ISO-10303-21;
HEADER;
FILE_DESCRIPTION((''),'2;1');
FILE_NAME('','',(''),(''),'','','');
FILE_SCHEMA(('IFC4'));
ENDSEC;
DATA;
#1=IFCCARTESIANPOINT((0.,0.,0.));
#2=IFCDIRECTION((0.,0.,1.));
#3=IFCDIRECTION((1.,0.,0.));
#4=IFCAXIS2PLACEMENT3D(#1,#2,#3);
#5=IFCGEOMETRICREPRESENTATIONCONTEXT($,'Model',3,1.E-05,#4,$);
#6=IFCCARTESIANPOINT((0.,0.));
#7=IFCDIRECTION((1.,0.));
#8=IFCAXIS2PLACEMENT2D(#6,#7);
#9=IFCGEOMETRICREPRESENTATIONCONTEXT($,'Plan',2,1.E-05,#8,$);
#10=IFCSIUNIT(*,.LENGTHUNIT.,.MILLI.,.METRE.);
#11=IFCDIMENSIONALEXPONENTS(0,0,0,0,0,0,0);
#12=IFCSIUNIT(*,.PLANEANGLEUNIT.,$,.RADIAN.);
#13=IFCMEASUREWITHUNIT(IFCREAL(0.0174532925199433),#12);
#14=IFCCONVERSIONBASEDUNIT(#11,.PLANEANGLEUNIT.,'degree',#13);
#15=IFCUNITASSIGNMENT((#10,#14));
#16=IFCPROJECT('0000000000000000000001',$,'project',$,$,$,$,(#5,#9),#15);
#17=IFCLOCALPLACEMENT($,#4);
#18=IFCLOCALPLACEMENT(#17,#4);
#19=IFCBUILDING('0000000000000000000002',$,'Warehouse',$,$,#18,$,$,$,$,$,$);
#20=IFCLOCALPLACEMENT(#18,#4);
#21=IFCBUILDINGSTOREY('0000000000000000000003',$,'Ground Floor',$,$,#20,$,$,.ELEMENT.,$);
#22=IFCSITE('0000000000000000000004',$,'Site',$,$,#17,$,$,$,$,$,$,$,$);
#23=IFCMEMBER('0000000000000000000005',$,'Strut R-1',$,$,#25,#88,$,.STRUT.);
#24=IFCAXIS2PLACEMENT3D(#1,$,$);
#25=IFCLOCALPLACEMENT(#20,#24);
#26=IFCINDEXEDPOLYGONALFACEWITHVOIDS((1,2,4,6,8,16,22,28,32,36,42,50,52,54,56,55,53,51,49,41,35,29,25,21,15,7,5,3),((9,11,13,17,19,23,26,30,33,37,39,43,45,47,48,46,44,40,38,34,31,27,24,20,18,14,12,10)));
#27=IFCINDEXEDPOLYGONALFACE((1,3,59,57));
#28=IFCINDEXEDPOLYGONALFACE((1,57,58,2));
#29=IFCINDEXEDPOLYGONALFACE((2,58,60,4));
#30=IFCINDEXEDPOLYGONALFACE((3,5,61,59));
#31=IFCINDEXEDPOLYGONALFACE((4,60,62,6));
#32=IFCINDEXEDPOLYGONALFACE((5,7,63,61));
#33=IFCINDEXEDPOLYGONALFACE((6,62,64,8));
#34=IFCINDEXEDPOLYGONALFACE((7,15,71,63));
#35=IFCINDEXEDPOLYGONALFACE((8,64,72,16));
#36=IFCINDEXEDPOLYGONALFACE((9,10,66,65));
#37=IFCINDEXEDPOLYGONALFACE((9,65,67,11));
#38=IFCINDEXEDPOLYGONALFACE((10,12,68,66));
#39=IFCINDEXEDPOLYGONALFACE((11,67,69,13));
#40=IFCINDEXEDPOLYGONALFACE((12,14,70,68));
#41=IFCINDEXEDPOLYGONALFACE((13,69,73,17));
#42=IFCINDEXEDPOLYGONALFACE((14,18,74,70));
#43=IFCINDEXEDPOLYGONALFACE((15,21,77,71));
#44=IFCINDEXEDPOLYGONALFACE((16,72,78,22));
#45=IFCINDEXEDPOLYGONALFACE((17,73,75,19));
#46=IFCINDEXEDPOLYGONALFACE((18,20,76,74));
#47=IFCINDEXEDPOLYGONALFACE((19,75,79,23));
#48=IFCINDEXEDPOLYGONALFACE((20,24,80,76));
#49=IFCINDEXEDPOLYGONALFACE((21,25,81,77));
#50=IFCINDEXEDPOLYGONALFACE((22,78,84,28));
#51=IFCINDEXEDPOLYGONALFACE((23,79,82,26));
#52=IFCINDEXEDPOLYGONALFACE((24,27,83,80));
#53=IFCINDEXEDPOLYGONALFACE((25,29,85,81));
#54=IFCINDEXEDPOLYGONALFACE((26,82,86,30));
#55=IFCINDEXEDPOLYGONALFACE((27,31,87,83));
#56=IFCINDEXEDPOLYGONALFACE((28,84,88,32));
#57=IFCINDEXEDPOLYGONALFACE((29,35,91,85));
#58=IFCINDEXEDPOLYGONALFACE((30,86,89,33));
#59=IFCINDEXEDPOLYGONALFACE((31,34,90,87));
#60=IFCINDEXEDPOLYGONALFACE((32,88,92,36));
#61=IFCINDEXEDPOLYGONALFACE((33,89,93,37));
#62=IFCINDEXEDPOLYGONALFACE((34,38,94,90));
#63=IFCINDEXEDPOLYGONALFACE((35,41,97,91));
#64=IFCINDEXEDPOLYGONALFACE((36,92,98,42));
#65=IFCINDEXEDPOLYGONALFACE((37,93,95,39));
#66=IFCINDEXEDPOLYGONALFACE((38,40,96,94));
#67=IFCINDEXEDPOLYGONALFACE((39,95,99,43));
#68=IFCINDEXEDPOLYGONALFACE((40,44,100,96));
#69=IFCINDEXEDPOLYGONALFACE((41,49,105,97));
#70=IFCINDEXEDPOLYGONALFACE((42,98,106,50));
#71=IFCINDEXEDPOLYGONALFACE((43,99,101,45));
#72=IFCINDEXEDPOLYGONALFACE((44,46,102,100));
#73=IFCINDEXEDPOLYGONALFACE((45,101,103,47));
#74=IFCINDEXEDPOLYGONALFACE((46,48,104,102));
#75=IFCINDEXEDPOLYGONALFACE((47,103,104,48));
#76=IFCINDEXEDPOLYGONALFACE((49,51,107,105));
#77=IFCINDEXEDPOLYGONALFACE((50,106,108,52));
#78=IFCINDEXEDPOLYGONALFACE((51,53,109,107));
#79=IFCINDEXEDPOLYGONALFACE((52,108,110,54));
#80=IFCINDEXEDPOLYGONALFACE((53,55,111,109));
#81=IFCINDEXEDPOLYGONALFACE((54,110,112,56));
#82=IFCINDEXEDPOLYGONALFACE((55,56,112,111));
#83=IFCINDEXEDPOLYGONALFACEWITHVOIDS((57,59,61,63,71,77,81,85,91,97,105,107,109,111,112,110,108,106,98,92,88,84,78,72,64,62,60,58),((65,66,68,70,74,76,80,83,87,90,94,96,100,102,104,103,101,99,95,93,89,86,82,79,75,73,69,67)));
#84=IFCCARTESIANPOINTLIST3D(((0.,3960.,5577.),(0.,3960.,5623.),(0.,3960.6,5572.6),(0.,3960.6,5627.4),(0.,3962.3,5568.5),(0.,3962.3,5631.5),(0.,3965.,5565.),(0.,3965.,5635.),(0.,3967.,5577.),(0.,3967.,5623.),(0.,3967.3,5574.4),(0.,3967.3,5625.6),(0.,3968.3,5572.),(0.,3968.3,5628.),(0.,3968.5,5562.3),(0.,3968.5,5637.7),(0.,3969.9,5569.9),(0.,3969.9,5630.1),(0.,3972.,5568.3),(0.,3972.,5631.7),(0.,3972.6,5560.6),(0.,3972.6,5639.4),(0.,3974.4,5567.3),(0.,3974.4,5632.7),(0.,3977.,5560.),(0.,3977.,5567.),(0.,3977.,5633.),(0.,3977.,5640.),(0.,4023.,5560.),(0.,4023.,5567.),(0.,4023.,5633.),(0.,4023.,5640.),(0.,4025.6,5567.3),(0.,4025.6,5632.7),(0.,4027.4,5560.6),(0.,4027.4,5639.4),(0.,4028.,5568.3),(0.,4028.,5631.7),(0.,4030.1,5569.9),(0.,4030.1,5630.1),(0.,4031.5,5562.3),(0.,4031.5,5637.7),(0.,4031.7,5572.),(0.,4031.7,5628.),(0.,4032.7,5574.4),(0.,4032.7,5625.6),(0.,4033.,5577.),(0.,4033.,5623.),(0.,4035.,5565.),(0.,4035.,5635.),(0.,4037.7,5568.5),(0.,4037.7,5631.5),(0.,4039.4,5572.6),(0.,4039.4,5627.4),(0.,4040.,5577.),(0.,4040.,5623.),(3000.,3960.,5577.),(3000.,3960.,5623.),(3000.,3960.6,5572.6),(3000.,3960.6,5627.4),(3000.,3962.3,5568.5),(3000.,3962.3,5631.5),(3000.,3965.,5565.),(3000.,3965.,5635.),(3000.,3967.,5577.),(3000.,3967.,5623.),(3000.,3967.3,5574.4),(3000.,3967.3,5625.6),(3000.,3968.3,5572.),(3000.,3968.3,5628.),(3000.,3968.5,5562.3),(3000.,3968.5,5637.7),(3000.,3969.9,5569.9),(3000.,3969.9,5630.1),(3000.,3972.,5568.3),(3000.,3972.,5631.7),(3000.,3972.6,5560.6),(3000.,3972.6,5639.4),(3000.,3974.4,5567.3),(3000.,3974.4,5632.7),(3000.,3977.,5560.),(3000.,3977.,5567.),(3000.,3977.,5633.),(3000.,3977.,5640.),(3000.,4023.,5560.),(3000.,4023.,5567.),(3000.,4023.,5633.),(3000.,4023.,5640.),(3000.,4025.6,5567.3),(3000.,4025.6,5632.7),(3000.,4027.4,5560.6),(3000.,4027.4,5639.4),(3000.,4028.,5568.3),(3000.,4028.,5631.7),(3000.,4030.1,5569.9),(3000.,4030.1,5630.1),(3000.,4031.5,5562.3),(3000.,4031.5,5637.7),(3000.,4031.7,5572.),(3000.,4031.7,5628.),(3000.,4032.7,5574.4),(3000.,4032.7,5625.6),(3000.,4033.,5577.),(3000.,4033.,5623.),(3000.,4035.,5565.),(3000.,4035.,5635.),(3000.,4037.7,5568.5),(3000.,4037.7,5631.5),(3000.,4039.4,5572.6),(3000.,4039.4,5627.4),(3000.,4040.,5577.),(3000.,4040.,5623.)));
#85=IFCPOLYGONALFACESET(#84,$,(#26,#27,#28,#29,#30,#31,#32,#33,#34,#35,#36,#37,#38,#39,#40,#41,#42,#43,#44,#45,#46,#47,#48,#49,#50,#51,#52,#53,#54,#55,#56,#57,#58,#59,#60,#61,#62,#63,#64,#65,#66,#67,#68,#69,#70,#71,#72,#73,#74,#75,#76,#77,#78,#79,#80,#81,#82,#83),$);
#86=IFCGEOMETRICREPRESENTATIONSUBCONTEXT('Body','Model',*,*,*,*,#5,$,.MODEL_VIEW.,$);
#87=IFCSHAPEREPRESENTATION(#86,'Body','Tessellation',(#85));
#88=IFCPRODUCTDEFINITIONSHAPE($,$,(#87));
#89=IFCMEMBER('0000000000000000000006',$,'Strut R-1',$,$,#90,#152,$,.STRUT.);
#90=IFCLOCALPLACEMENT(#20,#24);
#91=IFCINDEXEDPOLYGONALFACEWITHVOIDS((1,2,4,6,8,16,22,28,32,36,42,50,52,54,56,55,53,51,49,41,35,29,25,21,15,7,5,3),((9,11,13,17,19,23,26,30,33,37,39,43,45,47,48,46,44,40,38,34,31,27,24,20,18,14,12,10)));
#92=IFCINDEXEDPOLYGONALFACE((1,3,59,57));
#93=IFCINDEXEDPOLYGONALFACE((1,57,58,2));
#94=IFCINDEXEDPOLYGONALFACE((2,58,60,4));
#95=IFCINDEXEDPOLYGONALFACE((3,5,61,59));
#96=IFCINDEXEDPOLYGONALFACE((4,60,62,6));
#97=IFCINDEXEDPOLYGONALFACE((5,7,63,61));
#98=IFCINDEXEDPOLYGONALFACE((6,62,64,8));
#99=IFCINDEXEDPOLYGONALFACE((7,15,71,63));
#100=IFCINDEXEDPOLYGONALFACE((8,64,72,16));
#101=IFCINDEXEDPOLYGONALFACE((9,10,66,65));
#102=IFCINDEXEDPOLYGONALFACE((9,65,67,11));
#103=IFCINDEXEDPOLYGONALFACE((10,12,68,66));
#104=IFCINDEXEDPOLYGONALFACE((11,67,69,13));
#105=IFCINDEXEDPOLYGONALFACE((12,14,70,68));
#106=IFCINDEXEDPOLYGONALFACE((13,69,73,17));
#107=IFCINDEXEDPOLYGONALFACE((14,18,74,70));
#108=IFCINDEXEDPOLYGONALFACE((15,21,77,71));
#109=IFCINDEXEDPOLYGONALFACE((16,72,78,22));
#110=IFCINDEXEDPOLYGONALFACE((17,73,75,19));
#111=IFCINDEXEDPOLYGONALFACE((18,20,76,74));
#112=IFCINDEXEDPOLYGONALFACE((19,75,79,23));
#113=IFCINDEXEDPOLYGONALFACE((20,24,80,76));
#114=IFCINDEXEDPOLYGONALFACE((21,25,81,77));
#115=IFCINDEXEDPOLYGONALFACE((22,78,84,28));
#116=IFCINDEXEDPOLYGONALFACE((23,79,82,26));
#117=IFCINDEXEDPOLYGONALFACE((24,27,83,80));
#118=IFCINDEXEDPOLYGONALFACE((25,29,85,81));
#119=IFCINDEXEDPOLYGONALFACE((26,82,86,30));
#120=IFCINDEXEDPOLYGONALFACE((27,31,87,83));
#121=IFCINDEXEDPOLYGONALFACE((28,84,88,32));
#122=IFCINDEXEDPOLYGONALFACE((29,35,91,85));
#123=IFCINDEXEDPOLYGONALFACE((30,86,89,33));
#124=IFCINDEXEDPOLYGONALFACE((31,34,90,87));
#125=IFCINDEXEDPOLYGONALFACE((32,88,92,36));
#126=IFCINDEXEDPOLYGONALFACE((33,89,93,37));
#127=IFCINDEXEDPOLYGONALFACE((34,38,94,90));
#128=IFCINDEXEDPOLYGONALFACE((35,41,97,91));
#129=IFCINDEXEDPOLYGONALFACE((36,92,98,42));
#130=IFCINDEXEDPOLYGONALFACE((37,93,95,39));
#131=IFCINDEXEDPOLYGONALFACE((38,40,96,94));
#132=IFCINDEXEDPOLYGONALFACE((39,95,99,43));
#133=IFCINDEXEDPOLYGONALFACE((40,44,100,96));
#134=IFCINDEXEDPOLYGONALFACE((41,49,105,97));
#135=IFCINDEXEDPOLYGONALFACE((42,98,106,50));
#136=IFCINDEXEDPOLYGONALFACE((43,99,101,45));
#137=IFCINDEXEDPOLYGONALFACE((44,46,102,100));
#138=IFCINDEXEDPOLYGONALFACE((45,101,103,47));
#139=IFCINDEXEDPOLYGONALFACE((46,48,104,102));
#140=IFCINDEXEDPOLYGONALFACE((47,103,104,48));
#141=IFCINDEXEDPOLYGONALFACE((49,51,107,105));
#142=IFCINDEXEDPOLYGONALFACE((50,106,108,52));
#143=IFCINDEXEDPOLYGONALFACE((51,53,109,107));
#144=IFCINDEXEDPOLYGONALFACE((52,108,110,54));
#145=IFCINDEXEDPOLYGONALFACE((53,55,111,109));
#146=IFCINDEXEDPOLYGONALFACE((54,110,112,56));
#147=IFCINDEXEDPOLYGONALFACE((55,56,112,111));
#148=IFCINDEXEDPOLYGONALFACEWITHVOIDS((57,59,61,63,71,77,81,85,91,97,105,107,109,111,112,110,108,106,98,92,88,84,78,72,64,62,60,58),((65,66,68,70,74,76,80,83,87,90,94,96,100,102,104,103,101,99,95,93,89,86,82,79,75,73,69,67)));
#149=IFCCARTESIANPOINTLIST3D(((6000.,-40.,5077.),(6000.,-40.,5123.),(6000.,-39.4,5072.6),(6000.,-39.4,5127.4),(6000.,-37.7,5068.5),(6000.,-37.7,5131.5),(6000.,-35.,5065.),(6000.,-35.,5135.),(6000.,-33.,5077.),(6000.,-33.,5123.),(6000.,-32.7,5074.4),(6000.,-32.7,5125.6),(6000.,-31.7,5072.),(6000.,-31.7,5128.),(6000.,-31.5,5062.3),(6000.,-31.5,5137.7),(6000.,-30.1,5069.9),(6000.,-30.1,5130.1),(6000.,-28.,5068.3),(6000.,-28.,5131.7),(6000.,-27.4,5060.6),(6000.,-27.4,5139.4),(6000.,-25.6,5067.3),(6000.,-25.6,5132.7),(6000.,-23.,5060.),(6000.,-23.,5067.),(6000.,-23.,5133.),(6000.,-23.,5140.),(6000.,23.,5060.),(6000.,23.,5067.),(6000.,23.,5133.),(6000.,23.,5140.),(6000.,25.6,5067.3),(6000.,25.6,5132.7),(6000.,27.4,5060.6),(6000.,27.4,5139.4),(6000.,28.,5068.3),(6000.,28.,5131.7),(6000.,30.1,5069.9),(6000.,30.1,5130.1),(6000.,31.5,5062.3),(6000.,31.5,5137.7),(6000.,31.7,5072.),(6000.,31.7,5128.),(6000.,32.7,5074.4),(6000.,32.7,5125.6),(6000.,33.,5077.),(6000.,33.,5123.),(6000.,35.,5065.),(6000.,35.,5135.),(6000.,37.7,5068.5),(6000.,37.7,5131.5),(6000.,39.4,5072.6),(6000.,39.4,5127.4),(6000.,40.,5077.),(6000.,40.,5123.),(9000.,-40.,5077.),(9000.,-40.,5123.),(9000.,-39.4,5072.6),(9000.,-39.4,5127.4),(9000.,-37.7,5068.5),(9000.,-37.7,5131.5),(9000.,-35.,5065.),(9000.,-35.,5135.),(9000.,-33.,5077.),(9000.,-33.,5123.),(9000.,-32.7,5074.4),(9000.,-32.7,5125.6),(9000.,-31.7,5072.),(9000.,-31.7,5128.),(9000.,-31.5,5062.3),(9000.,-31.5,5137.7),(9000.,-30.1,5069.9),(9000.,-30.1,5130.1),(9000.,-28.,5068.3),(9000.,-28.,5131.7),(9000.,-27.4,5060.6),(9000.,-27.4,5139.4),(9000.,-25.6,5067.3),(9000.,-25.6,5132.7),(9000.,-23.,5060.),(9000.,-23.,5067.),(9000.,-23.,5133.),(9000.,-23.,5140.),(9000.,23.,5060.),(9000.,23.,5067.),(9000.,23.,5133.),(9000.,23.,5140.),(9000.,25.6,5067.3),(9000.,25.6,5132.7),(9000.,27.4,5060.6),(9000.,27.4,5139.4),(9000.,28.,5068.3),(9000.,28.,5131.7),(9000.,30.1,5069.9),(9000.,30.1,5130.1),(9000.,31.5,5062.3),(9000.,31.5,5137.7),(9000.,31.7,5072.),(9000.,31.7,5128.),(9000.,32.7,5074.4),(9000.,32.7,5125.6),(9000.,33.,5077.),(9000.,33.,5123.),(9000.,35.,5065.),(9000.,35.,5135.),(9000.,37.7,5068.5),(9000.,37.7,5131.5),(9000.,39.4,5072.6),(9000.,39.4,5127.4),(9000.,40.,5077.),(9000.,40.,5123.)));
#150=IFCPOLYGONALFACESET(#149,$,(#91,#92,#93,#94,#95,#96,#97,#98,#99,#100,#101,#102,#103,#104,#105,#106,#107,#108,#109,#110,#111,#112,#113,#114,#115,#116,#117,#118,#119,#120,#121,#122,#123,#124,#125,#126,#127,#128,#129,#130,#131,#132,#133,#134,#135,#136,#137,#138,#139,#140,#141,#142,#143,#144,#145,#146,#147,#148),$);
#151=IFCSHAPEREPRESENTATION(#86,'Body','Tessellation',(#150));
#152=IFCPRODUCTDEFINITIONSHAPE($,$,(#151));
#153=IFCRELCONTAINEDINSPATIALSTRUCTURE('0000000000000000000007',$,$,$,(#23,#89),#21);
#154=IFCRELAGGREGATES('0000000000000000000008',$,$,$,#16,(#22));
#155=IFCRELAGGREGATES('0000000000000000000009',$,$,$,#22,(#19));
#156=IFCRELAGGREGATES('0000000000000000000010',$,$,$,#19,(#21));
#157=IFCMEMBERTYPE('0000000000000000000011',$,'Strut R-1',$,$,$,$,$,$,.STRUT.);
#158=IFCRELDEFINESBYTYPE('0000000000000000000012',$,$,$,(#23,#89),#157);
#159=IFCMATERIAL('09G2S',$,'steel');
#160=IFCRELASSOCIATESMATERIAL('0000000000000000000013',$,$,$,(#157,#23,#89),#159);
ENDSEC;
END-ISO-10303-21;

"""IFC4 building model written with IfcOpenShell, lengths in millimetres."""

from ifc_helpers import new_model, entity, si_unit, converted_unit, frame, origin_with_axes, origin_2d_with_axis, place, context, subcontext, project, spatial, hollow_rectangle, extrude, material, material_profile, profile_set, profile_usage, type_object, element, save


model = new_model("IFC4")

# Units and contexts
model_context = context("Model", 3, precision=1e-05, world=origin_with_axes())
plan_context = context("Plan", 2, precision=1e-05, world=origin_2d_with_axis())
body_context = subcontext(model_context, "Body", "Model", "MODEL_VIEW")
ifc_project = project(units=[si_unit("LENGTHUNIT", "METRE", prefix="MILLI"), converted_unit("PLANEANGLEUNIT", "degree", entity("IfcReal", 0.0174532925199433), si_unit("PLANEANGLEUNIT", "RADIAN"), dimensions=[0, 0, 0, 0, 0, 0, 0])], contexts=[model_context, plan_context])

# Site, building, storey
site_placement = place(None, origin_with_axes())
site = spatial("IfcSite", under=ifc_project, at=site_placement, Name="Site")
building_placement = place(site_placement, origin_with_axes())
building = spatial("IfcBuilding", under=site, at=building_placement, Name="Warehouse")
storey_placement = place(building_placement, origin_with_axes())
storey = spatial("IfcBuildingStorey", under=building, at=storey_placement, Name="Ground Floor", CompositionType="ELEMENT")

# Members
ifc_material_1 = material(Name="09G2S", Category="steel")
ifc_material_profile_1 = material_profile(ifc_material_1, hollow_rectangle(XDim=80.0, YDim=80.0, WallThickness=7.0, InnerFilletRadius=10.0, OuterFilletRadius=17.0))
ifc_profile_set_1 = profile_set([ifc_material_profile_1], Name="PK80x7_09G2S")
member_type_1 = type_object("IfcMemberType", Name="Strut R-1", PredefinedType="STRUT", material=ifc_profile_set_1)
ifc_profile_usage_1 = profile_usage(ifc_profile_set_1, cardinal=5)
member_1_placement = place(storey_placement, frame((0.0, 4000.0, 5600.0), z_axis=(1.0, 0.0, 0.0), x_axis=(0.0, 1.0, 0.0)))
element("IfcMember", 1, at=member_1_placement, inside=storey, type_object=member_type_1, material=ifc_profile_usage_1, Name="Strut R-1", PredefinedType="STRUT", context=body_context, shape_type="SweptSolid", body=[
    extrude(hollow_rectangle(XDim=80.0, YDim=80.0, WallThickness=7.0, InnerFilletRadius=10.0, OuterFilletRadius=17.0), origin_with_axes(), (0.0, 0.0, 1.0), 3000.0),
])
ifc_profile_usage_2 = profile_usage(ifc_profile_set_1, cardinal=5)
member_2_placement = place(storey_placement, frame((6000.0, 0.0, 5100.0), z_axis=(1.0, 0.0, 0.0), x_axis=(0.0, 1.0, 0.0)))
element("IfcMember", 2, at=member_2_placement, inside=storey, type_object=member_type_1, material=ifc_profile_usage_2, Name="Strut R-1", PredefinedType="STRUT", context=body_context, shape_type="SweptSolid", body=[
    extrude(hollow_rectangle(XDim=80.0, YDim=80.0, WallThickness=7.0, InnerFilletRadius=10.0, OuterFilletRadius=17.0), origin_with_axes(), (0.0, 0.0, 1.0), 3000.0),
])

save(model, "model.ifc")
